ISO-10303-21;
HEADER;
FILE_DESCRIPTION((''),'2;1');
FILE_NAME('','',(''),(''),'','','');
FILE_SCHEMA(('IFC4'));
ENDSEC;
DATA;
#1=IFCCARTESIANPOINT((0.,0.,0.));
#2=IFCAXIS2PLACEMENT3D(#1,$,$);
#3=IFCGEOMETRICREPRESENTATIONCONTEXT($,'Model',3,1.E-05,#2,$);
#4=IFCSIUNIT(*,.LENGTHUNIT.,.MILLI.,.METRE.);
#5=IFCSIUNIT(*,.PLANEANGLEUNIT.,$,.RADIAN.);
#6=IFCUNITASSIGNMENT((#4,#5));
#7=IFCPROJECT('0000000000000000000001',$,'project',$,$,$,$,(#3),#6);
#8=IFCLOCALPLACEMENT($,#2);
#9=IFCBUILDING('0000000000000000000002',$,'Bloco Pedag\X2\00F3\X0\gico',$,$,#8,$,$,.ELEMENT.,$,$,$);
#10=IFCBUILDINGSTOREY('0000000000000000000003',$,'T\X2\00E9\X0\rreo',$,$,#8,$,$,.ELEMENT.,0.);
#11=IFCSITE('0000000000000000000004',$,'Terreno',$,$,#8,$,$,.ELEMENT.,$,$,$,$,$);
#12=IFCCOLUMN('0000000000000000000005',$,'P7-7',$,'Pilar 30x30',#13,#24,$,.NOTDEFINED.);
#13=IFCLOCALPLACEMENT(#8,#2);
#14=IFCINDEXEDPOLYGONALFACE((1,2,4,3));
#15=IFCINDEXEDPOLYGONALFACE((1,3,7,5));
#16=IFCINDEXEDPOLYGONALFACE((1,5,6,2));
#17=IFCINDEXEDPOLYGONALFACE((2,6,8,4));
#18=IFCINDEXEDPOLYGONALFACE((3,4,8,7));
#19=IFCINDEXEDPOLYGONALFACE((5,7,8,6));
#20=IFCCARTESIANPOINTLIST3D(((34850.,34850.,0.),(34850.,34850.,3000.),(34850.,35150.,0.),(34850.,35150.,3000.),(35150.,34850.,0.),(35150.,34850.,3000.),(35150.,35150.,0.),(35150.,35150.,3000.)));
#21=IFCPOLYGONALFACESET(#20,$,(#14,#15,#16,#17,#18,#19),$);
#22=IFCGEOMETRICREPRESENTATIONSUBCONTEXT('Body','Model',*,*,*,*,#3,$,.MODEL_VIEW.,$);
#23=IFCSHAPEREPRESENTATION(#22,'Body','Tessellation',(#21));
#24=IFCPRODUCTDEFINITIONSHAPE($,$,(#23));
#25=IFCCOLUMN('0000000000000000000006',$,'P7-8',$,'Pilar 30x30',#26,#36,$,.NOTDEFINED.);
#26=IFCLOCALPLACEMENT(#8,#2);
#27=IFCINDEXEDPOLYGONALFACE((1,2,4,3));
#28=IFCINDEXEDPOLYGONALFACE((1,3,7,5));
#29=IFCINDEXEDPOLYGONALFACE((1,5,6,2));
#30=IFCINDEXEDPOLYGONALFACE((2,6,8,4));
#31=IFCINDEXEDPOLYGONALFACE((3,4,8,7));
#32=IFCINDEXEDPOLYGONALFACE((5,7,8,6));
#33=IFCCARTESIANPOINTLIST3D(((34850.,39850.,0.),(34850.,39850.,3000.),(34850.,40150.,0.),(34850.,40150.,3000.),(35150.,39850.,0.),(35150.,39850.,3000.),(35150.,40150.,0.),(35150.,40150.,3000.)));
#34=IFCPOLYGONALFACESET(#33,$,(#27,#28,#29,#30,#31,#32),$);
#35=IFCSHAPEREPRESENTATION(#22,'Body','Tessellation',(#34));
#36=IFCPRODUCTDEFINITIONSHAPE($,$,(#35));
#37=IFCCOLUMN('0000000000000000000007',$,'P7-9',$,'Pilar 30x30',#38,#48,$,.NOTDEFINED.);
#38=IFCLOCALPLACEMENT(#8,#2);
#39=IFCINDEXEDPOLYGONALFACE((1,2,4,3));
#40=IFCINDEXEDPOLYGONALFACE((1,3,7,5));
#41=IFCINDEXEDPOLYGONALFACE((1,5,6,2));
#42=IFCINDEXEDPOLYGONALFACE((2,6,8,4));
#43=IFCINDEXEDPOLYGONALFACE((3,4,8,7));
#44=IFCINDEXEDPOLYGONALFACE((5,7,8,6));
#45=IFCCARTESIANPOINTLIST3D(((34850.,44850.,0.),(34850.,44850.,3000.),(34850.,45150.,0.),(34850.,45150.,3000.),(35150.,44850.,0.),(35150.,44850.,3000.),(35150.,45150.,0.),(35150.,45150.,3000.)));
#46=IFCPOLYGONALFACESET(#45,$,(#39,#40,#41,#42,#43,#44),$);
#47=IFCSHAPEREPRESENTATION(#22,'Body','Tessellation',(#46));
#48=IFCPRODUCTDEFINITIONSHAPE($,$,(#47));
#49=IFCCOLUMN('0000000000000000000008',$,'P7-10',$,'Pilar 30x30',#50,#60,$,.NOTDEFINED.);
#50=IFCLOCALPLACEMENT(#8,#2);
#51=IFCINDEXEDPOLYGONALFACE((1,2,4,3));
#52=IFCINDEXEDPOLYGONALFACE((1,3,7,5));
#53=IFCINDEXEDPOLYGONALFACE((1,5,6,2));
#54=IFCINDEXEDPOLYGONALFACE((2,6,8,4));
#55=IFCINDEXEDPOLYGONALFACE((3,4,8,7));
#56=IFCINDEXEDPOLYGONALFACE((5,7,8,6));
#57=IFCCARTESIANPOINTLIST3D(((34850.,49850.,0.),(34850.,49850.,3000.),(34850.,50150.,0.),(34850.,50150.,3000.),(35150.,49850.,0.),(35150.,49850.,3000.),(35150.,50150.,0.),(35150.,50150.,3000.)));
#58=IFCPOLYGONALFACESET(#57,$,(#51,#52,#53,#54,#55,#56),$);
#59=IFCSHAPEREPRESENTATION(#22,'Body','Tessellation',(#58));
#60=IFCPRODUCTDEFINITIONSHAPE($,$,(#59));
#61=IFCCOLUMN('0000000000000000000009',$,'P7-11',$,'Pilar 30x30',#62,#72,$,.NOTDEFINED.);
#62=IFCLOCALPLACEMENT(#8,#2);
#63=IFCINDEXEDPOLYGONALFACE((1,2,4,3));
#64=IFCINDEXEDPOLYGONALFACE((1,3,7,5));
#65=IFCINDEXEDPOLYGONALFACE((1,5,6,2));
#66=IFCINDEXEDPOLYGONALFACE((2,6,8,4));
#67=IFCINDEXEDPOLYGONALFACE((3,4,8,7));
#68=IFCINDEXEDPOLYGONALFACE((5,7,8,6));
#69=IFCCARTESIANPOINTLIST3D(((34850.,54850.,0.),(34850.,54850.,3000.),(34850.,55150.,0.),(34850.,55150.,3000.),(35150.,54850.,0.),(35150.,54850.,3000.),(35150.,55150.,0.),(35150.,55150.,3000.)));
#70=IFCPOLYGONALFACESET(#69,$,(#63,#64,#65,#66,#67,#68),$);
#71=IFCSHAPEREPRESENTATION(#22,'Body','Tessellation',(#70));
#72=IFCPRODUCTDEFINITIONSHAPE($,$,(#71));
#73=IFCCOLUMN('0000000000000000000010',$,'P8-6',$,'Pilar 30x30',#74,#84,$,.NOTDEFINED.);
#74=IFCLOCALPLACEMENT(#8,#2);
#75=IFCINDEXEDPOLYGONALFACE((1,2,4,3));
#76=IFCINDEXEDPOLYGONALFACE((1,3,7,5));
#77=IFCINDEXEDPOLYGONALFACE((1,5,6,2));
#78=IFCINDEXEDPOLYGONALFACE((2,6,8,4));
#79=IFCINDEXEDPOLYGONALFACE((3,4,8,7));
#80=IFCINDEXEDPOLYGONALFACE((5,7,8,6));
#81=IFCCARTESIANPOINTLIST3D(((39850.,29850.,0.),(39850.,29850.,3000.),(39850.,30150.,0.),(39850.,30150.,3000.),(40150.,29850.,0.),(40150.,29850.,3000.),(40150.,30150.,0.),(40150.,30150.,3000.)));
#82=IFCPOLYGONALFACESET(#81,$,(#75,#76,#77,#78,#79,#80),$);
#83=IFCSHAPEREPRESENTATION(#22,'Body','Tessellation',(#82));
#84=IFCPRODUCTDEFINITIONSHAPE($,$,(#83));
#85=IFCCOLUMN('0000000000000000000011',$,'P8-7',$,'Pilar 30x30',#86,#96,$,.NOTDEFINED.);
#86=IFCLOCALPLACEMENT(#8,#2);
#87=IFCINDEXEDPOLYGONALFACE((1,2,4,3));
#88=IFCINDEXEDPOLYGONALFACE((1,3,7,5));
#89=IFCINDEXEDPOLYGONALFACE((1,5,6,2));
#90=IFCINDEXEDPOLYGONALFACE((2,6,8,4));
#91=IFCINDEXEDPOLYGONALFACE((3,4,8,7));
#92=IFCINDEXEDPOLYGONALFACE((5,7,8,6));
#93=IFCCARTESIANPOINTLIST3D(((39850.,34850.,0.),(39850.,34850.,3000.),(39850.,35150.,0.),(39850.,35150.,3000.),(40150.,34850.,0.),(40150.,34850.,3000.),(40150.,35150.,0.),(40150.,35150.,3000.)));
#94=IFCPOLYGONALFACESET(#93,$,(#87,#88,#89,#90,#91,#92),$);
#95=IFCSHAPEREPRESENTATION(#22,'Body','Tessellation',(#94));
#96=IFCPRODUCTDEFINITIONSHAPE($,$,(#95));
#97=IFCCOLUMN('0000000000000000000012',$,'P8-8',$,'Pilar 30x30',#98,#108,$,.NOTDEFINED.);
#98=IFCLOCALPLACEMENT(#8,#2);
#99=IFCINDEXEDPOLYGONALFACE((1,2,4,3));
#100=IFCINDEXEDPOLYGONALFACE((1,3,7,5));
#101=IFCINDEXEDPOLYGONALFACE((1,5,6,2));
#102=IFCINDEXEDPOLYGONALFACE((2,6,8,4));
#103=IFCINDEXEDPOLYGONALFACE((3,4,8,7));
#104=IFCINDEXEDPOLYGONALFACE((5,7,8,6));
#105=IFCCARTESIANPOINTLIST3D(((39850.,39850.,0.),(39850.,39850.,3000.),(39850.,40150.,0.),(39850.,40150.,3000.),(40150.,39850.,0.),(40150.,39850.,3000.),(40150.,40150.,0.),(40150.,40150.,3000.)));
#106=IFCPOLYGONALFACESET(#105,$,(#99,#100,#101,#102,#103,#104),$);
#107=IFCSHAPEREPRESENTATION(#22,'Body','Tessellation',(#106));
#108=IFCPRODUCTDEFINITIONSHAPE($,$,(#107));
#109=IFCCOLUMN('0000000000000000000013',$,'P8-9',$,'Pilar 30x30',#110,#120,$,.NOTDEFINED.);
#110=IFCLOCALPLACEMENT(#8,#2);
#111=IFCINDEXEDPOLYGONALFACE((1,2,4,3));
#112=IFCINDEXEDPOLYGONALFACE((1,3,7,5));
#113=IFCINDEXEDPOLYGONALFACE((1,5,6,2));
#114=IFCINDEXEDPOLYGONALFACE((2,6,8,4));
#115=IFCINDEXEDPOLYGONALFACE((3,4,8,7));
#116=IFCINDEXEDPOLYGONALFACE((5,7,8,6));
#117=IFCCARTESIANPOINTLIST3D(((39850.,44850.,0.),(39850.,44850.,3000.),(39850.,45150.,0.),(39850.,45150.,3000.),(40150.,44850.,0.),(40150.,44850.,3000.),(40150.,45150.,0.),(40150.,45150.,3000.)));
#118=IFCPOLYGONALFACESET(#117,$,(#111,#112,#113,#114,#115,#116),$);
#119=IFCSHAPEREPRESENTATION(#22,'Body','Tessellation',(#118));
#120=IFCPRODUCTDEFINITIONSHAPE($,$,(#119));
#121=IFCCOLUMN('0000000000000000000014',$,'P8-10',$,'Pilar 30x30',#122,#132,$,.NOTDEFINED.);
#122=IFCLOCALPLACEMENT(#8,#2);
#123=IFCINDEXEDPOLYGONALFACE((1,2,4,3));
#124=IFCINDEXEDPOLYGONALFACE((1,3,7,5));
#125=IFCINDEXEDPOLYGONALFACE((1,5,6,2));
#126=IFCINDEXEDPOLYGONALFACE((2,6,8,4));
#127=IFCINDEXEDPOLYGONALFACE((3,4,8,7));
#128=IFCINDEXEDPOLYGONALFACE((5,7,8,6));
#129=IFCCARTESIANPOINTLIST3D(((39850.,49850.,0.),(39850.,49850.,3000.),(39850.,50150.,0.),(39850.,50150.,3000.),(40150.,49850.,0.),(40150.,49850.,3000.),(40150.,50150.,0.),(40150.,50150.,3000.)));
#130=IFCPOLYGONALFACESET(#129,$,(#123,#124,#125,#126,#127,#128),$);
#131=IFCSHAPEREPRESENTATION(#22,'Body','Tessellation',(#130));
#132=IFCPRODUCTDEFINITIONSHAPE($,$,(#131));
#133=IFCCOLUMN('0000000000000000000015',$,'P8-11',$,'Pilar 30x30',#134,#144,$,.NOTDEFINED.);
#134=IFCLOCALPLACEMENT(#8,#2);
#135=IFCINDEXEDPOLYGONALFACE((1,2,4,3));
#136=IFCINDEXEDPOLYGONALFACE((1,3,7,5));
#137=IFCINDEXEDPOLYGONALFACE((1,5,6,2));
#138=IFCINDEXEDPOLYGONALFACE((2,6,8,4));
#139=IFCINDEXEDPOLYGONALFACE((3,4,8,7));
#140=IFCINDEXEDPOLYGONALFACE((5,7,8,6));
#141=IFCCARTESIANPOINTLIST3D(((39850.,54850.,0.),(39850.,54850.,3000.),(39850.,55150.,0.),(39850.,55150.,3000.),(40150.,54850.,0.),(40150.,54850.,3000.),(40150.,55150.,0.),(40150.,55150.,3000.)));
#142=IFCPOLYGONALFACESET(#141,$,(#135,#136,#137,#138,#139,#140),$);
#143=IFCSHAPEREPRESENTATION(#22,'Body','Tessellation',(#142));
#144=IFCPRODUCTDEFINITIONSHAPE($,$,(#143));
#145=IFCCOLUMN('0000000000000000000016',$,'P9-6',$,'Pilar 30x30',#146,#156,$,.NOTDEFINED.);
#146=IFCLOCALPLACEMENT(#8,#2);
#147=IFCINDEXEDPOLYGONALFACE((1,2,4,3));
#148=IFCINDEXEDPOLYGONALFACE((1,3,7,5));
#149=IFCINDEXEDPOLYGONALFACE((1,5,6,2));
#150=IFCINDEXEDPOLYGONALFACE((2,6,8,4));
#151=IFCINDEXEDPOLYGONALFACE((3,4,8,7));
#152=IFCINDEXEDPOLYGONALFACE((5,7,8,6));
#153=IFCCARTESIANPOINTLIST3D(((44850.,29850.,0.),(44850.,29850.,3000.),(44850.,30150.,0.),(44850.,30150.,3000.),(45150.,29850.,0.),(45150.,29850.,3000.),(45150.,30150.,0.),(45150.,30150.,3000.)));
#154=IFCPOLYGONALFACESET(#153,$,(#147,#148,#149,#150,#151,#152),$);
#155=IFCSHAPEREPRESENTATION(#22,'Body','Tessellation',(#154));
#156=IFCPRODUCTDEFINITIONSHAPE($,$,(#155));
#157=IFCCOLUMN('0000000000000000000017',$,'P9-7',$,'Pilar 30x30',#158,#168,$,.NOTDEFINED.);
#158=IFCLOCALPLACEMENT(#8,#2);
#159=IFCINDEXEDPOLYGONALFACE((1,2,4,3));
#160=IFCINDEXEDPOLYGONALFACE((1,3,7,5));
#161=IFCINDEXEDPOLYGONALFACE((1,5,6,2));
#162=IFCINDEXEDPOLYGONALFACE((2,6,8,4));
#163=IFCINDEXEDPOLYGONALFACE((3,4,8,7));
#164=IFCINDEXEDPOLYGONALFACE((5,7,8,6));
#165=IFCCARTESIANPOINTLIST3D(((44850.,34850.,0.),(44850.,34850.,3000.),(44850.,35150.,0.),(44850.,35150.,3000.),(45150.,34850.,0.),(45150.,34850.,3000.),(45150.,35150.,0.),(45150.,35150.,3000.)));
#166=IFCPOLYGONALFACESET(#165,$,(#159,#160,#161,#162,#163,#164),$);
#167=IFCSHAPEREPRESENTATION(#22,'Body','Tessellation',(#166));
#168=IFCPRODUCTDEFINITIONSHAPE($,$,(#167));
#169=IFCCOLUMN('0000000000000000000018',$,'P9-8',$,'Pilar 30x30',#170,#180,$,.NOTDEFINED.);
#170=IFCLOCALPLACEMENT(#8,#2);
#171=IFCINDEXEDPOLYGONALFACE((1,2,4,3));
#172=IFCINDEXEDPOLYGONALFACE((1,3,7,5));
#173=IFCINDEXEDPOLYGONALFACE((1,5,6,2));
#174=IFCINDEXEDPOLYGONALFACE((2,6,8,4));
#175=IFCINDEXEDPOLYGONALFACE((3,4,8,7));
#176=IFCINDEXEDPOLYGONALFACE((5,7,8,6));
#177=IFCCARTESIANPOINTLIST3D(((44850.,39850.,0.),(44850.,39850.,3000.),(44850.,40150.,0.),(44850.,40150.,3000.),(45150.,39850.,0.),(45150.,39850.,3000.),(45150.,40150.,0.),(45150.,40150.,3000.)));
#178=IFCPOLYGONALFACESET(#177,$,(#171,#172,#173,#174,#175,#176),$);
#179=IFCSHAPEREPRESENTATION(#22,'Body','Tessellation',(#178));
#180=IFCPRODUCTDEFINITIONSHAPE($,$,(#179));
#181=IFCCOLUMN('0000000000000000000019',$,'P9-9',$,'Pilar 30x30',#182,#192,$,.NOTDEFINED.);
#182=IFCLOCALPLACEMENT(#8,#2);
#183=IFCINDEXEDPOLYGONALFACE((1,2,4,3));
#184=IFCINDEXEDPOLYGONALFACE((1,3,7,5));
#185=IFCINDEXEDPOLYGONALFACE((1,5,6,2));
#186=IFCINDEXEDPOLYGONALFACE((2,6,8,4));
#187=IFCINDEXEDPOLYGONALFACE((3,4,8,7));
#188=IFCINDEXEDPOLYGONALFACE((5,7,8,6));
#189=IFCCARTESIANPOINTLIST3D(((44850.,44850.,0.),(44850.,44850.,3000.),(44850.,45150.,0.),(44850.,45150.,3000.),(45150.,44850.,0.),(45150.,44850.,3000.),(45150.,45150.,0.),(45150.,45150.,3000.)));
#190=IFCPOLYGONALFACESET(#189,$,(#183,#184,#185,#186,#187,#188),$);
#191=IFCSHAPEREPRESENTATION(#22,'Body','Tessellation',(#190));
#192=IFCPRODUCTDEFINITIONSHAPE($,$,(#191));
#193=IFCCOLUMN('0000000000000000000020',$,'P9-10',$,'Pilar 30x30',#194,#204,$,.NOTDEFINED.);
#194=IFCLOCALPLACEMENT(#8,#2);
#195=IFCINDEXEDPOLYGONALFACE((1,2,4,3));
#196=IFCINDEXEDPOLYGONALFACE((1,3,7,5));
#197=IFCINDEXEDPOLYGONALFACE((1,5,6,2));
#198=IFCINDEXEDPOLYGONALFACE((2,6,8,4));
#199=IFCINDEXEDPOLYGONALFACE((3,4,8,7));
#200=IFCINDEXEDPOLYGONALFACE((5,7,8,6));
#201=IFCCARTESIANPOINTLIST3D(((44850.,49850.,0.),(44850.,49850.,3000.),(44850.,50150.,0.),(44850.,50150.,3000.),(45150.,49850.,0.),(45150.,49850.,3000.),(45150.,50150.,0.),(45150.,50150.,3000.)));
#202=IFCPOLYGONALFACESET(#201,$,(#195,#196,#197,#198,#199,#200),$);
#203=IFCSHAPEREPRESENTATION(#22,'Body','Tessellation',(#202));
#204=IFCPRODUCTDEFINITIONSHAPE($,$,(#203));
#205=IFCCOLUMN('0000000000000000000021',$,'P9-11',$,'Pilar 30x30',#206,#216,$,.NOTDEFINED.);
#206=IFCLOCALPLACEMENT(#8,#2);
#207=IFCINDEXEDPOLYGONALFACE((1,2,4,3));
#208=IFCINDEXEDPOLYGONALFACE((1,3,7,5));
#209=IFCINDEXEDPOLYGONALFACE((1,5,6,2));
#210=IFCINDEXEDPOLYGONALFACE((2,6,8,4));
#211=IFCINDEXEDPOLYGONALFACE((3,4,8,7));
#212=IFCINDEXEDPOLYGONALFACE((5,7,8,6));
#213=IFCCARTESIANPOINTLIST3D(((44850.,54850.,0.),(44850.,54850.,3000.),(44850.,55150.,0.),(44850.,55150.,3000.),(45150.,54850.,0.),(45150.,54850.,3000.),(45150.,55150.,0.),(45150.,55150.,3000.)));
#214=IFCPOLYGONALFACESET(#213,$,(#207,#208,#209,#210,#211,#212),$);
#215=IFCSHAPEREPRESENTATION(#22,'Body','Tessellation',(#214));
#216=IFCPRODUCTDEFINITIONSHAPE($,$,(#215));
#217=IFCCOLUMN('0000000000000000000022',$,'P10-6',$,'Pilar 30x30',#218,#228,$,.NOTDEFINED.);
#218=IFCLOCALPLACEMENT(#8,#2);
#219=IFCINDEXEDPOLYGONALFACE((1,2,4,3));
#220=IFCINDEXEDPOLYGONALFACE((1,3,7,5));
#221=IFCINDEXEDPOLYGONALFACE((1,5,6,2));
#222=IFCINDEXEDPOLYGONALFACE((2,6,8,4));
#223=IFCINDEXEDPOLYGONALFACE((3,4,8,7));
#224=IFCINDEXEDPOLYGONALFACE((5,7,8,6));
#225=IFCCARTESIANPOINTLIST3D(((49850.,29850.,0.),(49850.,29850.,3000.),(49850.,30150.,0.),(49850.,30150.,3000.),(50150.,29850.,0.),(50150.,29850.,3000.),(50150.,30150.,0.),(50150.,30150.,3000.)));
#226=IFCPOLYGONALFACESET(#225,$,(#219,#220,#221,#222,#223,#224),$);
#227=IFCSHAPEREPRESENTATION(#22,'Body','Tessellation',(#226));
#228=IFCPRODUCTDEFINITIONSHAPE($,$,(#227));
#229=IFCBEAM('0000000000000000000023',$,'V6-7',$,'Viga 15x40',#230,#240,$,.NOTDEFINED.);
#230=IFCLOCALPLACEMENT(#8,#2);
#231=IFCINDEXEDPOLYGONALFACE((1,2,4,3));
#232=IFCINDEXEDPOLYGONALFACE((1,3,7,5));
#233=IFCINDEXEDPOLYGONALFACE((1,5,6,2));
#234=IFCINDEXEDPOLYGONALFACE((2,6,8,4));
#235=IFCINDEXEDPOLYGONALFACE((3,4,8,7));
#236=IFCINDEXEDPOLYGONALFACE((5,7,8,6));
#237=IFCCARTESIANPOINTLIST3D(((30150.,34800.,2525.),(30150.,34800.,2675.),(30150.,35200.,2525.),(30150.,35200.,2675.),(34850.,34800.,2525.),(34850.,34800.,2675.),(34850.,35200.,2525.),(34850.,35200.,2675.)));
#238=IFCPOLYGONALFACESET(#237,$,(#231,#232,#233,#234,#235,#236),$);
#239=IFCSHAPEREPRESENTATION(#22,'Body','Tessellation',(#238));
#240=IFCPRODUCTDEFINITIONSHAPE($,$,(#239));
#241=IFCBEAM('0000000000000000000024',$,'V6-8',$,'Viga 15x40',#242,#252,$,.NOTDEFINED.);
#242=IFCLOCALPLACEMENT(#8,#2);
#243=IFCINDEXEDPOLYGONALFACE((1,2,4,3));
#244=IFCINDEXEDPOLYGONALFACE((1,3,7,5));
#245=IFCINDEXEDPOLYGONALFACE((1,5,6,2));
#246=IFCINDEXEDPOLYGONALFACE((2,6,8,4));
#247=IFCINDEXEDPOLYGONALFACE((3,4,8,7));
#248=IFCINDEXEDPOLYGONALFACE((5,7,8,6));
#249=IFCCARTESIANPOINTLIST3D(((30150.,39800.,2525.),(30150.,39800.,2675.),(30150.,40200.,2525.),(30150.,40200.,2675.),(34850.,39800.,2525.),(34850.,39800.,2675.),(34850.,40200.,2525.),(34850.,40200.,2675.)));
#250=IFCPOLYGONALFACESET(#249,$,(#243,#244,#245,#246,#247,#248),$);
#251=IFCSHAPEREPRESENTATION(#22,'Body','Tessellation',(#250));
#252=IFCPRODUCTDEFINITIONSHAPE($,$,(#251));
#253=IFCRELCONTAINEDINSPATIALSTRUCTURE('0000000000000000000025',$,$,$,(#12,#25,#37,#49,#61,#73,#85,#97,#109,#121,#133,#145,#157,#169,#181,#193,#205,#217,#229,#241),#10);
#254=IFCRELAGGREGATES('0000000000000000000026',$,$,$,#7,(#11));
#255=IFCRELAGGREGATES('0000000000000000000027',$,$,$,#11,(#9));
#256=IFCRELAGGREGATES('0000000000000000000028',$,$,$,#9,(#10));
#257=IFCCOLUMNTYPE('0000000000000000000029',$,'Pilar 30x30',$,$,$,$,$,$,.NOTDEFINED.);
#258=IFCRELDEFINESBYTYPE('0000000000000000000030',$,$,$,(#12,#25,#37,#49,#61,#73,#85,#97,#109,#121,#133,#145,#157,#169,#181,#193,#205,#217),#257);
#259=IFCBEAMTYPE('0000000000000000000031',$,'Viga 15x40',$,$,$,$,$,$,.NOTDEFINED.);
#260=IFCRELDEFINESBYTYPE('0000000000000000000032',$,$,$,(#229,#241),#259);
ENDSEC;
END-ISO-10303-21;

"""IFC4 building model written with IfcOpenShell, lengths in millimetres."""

from ifc_helpers import new_model, si_unit, frame, origin, origin_2d, place, context, subcontext, project, spatial, rectangle, extrude, type_object, element, save


model = new_model("IFC4")

# Units and contexts
model_context = context("Model", 3, precision=1e-05, world=origin())
body_context = subcontext(model_context, "Body", "Model", "MODEL_VIEW")
ifc_project = project(units=[si_unit("LENGTHUNIT", "METRE", prefix="MILLI"), si_unit("PLANEANGLEUNIT", "RADIAN")], contexts=[model_context])

# Site, building, storey
placement = place(None, origin())
site = spatial("IfcSite", under=ifc_project, at=placement, Name="Terreno", CompositionType="ELEMENT")
building = spatial("IfcBuilding", under=site, at=placement, Name="Bloco Pedagógico", CompositionType="ELEMENT")
storey = spatial("IfcBuildingStorey", under=building, at=placement, Name="Térreo", CompositionType="ELEMENT", Elevation=0.0)

# Columns
column_type = type_object("IfcColumnType", Name="Pilar 30x30", PredefinedType="NOTDEFINED")
for number, where, z_axis, x_axis, name in (
    (1, (35000.0, 35000.0, 0.0), (0.0, 0.0, 1.0), (1.0, 0.0, 0.0), "P7-7"),
    (2, (35000.0, 40000.0, 0.0), (0.0, 0.0, 1.0), (1.0, 0.0, 0.0), "P7-8"),
    (3, (35000.0, 45000.0, 0.0), (0.0, 0.0, 1.0), (1.0, 0.0, 0.0), "P7-9"),
    (4, (35000.0, 50000.0, 0.0), (0.0, 0.0, 1.0), (1.0, 0.0, 0.0), "P7-10"),
    (5, (35000.0, 55000.0, 0.0), (0.0, 0.0, 1.0), (1.0, 0.0, 0.0), "P7-11"),
    (6, (40000.0, 30000.0, 0.0), (0.0, 0.0, 1.0), (1.0, 0.0, 0.0), "P8-6"),
    (7, (40000.0, 35000.0, 0.0), (0.0, 0.0, 1.0), (1.0, 0.0, 0.0), "P8-7"),
    (8, (40000.0, 40000.0, 0.0), (0.0, 0.0, 1.0), (1.0, 0.0, 0.0), "P8-8"),
    (9, (40000.0, 45000.0, 0.0), (0.0, 0.0, 1.0), (1.0, 0.0, 0.0), "P8-9"),
    (10, (40000.0, 50000.0, 0.0), (0.0, 0.0, 1.0), (1.0, 0.0, 0.0), "P8-10"),
    (11, (40000.0, 55000.0, 0.0), (0.0, 0.0, 1.0), (1.0, 0.0, 0.0), "P8-11"),
    (12, (45000.0, 30000.0, 0.0), (0.0, 0.0, 1.0), (1.0, 0.0, 0.0), "P9-6"),
    (13, (45000.0, 35000.0, 0.0), (0.0, 0.0, 1.0), (1.0, 0.0, 0.0), "P9-7"),
    (14, (45000.0, 40000.0, 0.0), (0.0, 0.0, 1.0), (1.0, 0.0, 0.0), "P9-8"),
    (15, (45000.0, 45000.0, 0.0), (0.0, 0.0, 1.0), (1.0, 0.0, 0.0), "P9-9"),
    (16, (45000.0, 50000.0, 0.0), (0.0, 0.0, 1.0), (1.0, 0.0, 0.0), "P9-10"),
    (17, (45000.0, 55000.0, 0.0), (0.0, 0.0, 1.0), (1.0, 0.0, 0.0), "P9-11"),
    (18, (50000.0, 30000.0, 0.0), (0.0, 0.0, 1.0), (1.0, 0.0, 0.0), "P10-6"),
):
    element("IfcColumn", number, at=place(None, frame(where, z_axis=z_axis, x_axis=x_axis)), inside=storey, type_object=column_type, Name=name, ObjectType="Pilar 30x30", PredefinedType="NOTDEFINED", context=body_context, shape_type="SweptSolid", body=[
        extrude(rectangle(XDim=300.0, YDim=300.0, at=origin_2d()), None, (0.0, 0.0, 1.0), 3000.0),
    ])

# Beams
beam_type = type_object("IfcBeamType", Name="Viga 15x40", PredefinedType="NOTDEFINED")
for number, where, z_axis, x_axis, name in (
    (19, (30150.0, 35000.0, 2600.0), (1.0, 0.0, 0.0), (0.0, 1.0, 0.0), "V6-7"),
    (20, (30150.0, 40000.0, 2600.0), (1.0, 0.0, 0.0), (0.0, 1.0, 0.0), "V6-8"),
):
    element("IfcBeam", number, at=place(None, frame(where, z_axis=z_axis, x_axis=x_axis)), inside=storey, type_object=beam_type, Name=name, ObjectType="Viga 15x40", PredefinedType="NOTDEFINED", context=body_context, shape_type="SweptSolid", body=[
        extrude(rectangle(XDim=400.0, YDim=150.0, at=origin_2d()), None, (0.0, 0.0, 1.0), 4700.0),
    ])

save(model, "model.ifc")
